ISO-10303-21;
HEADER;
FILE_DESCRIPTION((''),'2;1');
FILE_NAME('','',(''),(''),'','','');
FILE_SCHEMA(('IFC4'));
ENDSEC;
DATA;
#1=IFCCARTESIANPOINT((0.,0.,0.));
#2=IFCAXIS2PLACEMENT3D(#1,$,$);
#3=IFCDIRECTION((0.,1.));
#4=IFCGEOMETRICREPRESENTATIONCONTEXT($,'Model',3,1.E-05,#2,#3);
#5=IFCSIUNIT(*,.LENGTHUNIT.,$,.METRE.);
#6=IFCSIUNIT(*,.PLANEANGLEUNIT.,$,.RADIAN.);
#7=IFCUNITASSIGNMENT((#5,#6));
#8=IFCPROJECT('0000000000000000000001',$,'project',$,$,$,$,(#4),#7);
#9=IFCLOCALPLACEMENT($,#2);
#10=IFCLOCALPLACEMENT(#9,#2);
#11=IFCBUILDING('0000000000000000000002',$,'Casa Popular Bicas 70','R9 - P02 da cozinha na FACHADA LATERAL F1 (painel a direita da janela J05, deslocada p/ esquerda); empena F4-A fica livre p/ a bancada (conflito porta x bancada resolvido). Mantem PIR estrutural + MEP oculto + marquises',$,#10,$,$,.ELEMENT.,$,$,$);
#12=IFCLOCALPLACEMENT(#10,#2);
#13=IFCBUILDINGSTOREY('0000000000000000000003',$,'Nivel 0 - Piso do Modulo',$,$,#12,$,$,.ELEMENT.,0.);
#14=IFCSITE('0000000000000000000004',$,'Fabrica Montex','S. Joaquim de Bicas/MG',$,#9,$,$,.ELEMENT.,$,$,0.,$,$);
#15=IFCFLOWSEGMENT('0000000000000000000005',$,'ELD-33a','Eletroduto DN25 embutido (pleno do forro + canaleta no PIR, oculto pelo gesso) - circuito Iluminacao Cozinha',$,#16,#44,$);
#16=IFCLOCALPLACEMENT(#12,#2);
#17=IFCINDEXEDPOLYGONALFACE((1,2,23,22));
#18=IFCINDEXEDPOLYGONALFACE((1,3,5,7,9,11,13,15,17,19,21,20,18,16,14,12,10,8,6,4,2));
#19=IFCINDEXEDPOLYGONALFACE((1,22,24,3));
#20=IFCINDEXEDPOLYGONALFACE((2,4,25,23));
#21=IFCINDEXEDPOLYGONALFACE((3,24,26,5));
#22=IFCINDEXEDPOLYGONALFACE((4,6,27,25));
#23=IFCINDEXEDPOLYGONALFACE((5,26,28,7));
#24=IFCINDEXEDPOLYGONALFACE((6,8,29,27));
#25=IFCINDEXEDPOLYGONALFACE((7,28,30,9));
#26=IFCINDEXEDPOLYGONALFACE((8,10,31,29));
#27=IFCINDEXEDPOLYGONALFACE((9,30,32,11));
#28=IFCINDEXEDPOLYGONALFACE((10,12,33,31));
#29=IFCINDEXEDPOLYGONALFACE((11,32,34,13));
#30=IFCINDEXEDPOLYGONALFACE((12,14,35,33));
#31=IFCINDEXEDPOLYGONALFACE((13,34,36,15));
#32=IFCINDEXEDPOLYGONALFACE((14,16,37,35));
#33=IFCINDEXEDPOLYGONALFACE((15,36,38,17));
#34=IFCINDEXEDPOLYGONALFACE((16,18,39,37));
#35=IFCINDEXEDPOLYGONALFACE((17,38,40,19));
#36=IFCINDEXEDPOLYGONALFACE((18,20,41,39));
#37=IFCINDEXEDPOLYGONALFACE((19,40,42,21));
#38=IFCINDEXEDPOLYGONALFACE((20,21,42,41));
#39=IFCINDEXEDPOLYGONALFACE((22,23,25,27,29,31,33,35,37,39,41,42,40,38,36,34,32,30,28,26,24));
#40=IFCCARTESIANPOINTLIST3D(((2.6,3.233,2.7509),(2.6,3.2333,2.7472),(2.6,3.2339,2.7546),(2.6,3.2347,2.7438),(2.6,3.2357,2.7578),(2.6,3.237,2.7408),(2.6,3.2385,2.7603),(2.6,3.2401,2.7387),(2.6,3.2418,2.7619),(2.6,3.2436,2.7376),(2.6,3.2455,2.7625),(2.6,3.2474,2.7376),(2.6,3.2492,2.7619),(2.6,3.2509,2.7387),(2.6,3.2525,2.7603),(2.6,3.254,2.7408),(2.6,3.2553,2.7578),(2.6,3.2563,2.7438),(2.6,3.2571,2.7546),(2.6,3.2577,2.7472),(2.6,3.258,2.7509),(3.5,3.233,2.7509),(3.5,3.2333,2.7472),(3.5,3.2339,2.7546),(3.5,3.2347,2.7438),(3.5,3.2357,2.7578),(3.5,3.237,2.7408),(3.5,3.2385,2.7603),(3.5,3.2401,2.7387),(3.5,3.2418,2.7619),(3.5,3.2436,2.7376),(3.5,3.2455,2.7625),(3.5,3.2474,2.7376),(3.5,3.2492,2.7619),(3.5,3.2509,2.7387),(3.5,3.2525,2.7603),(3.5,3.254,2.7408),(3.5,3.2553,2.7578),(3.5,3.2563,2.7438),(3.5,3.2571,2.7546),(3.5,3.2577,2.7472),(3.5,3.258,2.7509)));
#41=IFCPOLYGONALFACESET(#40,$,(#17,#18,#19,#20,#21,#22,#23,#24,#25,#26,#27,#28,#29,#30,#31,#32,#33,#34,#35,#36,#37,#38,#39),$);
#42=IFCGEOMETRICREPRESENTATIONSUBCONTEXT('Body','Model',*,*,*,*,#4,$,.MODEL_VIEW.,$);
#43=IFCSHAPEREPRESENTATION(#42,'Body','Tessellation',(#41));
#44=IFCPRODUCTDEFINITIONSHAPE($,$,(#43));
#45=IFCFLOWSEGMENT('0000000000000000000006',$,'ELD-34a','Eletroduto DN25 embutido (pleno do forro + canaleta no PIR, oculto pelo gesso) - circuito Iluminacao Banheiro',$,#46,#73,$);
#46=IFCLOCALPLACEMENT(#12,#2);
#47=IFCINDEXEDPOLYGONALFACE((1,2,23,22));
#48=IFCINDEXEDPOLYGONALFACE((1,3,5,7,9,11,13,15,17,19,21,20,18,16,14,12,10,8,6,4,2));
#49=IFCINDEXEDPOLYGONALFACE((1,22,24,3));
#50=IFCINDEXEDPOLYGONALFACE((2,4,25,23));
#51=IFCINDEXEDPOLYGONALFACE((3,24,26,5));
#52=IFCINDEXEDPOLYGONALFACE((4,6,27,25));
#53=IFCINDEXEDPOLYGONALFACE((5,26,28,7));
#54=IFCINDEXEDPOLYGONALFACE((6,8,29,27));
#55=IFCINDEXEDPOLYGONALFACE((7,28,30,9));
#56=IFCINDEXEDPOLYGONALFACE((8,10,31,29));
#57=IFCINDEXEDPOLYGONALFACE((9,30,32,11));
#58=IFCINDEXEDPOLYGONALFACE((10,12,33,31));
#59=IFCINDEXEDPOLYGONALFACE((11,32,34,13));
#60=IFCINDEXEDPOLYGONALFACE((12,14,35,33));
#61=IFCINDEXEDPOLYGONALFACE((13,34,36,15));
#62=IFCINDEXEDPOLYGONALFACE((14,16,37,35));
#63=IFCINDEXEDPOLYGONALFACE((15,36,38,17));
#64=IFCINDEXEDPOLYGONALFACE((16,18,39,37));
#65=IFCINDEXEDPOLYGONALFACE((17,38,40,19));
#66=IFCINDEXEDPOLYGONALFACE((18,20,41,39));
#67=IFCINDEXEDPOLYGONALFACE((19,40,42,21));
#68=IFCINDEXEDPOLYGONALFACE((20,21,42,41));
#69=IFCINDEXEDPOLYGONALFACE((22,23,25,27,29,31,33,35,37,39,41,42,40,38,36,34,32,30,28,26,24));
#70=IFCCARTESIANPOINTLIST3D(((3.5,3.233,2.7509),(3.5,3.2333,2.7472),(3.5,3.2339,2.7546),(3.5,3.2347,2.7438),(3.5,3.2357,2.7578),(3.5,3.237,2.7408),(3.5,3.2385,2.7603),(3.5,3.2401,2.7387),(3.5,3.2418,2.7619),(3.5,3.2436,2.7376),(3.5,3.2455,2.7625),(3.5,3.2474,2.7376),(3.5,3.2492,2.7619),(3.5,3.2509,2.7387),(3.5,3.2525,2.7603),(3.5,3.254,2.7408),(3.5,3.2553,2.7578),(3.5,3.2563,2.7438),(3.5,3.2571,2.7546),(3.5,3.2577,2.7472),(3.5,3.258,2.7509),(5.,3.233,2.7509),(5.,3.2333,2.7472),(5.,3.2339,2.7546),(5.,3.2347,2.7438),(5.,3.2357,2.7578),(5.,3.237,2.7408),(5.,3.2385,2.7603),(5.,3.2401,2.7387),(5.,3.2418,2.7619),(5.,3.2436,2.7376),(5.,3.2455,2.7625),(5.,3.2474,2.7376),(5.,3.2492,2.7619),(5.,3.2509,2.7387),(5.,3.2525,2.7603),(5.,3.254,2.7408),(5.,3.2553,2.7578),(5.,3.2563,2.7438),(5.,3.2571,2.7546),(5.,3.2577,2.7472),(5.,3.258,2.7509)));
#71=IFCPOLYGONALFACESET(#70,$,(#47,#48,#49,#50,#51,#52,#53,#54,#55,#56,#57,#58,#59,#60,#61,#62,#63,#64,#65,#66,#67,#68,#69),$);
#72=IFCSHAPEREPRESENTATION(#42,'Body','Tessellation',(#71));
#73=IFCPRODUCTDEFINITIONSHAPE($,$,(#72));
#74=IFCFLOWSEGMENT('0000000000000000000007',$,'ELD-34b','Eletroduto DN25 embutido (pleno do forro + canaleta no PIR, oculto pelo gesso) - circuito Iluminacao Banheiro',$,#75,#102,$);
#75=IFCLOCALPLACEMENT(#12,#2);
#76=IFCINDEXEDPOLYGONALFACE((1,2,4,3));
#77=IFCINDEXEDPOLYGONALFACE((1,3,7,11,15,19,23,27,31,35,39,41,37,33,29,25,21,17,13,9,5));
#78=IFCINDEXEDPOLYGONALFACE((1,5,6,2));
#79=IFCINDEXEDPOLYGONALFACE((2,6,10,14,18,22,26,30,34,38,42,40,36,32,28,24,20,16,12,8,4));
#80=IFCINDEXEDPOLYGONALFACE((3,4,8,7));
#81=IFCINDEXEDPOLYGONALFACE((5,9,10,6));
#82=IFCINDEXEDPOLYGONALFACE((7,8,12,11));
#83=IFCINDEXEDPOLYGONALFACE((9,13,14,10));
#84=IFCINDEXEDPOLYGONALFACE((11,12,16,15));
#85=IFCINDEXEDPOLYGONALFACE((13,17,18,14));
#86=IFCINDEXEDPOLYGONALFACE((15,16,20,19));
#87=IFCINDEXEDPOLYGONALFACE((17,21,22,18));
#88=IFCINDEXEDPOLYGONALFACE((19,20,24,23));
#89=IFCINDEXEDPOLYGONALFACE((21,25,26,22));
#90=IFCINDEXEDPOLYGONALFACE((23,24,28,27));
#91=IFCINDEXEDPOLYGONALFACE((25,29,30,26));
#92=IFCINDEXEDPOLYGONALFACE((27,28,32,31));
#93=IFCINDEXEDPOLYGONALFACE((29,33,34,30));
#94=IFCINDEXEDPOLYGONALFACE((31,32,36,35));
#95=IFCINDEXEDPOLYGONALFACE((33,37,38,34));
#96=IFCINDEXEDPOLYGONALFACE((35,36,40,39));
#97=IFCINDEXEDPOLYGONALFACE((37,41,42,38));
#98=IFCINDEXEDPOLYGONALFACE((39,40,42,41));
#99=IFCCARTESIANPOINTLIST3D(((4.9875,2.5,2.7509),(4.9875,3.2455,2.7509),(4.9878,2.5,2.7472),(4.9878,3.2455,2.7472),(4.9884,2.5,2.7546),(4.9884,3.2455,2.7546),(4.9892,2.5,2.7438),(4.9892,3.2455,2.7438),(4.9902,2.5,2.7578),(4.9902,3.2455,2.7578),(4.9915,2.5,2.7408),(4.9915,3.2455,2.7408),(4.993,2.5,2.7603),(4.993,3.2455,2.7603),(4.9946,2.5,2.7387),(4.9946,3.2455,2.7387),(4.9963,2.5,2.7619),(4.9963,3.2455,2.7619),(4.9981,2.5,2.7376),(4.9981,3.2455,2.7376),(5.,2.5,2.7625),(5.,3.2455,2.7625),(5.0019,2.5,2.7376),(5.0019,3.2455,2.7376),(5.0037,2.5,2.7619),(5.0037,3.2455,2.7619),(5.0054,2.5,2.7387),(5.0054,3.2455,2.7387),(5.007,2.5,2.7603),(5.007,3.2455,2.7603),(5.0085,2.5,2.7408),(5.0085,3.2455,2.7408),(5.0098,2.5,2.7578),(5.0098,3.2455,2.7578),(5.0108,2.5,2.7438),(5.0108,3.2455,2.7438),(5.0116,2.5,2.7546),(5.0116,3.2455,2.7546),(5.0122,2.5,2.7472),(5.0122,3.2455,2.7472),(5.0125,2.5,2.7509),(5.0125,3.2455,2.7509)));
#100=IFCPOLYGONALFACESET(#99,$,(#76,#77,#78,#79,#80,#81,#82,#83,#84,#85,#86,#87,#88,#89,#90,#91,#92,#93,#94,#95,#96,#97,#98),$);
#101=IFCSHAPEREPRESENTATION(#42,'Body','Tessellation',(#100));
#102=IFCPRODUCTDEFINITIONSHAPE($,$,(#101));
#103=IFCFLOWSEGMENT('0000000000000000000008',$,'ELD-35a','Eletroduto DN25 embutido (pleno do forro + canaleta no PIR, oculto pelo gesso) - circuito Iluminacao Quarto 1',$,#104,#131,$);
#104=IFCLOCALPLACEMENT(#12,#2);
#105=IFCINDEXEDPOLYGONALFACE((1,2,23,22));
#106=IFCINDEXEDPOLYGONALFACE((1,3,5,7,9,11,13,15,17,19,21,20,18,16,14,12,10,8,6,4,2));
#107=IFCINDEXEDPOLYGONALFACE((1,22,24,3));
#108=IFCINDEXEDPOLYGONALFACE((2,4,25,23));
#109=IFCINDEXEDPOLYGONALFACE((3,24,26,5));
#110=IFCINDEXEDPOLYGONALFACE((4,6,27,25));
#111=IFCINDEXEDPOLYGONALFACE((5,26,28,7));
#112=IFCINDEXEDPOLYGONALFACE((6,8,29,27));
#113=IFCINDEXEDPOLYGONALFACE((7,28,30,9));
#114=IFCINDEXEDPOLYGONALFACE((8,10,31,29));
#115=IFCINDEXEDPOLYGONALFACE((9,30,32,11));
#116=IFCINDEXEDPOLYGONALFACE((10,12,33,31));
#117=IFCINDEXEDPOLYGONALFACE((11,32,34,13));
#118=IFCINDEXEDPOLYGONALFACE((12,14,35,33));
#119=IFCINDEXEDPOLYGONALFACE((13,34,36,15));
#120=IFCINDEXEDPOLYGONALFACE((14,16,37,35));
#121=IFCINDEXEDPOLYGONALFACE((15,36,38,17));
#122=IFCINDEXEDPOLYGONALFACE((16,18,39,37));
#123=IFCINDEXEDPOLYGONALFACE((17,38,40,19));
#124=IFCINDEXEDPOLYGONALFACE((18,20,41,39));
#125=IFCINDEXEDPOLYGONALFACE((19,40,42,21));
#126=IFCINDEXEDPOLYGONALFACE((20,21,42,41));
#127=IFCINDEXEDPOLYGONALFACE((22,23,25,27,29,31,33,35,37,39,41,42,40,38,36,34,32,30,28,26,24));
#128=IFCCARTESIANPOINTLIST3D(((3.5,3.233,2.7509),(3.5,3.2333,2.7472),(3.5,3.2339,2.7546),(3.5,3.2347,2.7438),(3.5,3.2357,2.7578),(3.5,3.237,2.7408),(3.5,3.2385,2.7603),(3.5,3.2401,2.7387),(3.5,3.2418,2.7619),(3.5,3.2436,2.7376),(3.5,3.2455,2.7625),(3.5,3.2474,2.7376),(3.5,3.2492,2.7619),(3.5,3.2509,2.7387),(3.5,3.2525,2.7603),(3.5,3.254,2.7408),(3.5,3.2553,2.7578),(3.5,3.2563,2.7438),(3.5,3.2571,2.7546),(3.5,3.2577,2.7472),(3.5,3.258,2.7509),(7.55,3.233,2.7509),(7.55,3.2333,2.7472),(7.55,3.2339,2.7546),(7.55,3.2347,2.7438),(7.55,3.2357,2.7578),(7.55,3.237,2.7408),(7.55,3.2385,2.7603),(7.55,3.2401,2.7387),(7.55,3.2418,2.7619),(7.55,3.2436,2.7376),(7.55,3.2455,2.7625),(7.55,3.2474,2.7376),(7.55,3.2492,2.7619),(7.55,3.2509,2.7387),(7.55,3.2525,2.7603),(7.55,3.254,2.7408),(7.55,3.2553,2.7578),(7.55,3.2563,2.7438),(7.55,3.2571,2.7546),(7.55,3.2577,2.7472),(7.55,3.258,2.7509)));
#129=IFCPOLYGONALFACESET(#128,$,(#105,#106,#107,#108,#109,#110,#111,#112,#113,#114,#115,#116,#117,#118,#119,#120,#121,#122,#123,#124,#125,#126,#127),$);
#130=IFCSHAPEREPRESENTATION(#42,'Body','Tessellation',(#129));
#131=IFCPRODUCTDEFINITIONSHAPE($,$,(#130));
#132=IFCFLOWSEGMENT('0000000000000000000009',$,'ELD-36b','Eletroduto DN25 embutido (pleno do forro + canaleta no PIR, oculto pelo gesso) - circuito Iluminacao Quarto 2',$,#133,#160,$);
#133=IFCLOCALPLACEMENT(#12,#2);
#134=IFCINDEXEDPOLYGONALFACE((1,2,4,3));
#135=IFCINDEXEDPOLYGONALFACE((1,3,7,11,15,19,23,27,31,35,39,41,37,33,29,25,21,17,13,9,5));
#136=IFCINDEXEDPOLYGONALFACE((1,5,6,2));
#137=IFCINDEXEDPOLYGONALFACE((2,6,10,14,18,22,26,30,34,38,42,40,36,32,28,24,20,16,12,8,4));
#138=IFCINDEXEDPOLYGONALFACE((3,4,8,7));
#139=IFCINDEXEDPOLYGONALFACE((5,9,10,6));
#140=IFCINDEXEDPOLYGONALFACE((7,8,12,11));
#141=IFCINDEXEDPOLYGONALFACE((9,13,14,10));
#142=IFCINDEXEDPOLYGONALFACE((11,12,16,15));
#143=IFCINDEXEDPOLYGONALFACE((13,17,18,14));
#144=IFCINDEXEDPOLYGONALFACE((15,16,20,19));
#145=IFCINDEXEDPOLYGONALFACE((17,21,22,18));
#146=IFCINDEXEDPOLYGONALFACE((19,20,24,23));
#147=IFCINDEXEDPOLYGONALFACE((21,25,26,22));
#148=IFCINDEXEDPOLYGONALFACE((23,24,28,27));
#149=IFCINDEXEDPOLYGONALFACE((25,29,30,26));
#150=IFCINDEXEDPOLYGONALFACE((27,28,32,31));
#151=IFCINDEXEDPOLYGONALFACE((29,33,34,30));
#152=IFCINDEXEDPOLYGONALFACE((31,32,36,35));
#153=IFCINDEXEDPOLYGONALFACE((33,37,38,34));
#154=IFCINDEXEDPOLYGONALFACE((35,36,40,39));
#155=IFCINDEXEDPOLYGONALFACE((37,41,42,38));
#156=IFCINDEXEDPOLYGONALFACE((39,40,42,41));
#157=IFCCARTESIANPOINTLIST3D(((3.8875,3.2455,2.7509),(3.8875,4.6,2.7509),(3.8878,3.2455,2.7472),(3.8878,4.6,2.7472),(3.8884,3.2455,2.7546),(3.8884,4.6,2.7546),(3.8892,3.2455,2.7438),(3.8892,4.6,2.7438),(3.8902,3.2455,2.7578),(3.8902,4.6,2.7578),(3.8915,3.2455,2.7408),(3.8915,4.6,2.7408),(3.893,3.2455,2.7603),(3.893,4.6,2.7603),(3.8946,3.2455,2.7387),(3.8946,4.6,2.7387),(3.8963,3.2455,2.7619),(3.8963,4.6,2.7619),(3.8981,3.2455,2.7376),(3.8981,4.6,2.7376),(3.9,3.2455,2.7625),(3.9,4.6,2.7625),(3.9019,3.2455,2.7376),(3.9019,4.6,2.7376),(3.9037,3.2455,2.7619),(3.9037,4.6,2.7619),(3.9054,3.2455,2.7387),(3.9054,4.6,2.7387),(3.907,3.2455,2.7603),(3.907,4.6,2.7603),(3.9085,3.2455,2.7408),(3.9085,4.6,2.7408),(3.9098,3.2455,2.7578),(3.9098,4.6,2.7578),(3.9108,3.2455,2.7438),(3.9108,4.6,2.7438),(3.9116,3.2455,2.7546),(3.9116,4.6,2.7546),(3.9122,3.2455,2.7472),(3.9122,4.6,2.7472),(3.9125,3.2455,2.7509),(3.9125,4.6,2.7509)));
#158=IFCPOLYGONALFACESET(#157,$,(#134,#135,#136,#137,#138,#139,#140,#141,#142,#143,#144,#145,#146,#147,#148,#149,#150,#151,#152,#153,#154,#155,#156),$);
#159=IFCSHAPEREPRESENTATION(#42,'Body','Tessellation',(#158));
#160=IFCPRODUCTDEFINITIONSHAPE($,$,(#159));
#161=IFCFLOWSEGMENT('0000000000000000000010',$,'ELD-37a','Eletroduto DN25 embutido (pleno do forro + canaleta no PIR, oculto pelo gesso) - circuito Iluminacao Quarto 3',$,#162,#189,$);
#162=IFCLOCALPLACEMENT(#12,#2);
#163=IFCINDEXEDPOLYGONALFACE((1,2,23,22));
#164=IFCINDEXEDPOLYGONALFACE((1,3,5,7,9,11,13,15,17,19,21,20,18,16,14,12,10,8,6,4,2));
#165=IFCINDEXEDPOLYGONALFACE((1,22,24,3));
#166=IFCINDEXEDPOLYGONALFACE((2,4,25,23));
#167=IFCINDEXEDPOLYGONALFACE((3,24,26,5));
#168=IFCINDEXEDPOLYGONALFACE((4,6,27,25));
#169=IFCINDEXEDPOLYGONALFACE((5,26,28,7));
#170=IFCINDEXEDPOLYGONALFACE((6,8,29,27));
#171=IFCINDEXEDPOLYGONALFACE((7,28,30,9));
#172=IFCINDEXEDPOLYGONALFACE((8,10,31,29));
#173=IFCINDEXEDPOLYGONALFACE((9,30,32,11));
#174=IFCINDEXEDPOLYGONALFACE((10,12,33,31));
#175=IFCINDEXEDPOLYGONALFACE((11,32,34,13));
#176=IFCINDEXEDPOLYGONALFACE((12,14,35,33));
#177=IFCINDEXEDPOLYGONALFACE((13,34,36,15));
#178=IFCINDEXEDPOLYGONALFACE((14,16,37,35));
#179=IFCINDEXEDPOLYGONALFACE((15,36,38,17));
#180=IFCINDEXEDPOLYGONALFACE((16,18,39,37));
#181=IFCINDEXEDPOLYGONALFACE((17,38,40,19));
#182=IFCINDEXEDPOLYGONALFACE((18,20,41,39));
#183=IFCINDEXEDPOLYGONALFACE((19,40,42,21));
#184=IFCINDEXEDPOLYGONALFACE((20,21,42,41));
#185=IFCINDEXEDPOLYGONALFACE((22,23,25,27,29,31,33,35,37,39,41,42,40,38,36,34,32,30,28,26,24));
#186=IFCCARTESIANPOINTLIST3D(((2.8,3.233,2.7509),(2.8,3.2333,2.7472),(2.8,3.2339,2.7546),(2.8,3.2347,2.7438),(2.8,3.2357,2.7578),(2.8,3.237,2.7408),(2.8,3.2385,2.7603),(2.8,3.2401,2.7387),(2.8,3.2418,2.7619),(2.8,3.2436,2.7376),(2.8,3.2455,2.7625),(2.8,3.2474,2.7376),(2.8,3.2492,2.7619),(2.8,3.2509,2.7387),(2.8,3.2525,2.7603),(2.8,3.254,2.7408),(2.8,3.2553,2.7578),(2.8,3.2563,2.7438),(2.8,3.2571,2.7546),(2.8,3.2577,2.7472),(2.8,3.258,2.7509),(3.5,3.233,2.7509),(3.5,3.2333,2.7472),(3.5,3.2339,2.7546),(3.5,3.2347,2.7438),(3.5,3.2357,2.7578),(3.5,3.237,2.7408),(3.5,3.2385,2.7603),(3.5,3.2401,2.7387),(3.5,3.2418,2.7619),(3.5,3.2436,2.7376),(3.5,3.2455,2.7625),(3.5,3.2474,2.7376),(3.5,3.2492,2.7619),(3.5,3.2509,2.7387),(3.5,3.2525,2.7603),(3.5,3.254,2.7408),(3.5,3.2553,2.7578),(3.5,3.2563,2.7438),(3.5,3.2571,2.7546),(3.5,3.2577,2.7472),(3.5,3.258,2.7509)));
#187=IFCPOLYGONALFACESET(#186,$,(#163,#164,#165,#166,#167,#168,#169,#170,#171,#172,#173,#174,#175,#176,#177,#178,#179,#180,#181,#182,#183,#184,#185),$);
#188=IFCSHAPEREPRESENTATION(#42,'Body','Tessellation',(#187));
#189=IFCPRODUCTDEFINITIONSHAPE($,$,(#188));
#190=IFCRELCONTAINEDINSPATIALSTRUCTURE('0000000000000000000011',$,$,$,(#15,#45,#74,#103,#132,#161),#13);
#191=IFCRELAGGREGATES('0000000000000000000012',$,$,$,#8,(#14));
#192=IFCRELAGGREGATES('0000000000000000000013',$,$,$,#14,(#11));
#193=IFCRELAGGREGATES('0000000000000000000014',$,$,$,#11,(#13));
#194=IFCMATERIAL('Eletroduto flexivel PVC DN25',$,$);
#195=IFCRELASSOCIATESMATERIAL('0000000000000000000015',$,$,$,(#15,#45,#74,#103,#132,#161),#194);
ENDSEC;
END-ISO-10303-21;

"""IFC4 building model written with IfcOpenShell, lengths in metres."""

from ifc_helpers import new_model, si_unit, direction, frame, origin, origin_2d, place, context, subcontext, project, spatial, circle, extrude, material, element, save


model = new_model("IFC4")

# Units and contexts
model_context = context("Model", 3, precision=1e-05, world=origin(), true_north=direction((0.0, 1.0)))
body_context = subcontext(model_context, "Body", "Model", "MODEL_VIEW")
ifc_project = project(units=[si_unit("LENGTHUNIT", "METRE"), si_unit("PLANEANGLEUNIT", "RADIAN")], contexts=[model_context])

# Site, building, storey
site_placement = place(None, origin())
site = spatial("IfcSite", under=ifc_project, at=site_placement, Name="Fabrica Montex", Description="S. Joaquim de Bicas/MG", CompositionType="ELEMENT", RefElevation=0.0)
building_placement = place(site_placement, origin())
building = spatial("IfcBuilding", under=site, at=building_placement, Name="Casa Popular Bicas 70", Description="R9 - P02 da cozinha na FACHADA LATERAL F1 (painel a direita da janela J05, deslocada p/ esquerda); empena F4-A fica livre p/ a bancada (conflito porta x bancada resolvido). Mantem PIR estrutural + MEP oculto + marquises", CompositionType="ELEMENT")
storey_placement = place(building_placement, origin())
storey = spatial("IfcBuildingStorey", under=building, at=storey_placement, Name="Nivel 0 - Piso do Modulo", CompositionType="ELEMENT", Elevation=0.0)

# Flow segments
ifc_material_1 = material(Name="Eletroduto flexivel PVC DN25")
flow_segment_1_placement = place(storey_placement, frame((3.5, 3.2455, 2.75), z_axis=(-1.0, 0.0, 0.0), x_axis=(0.0, 0.0, 1.0)))
element("IfcFlowSegment", 1, at=flow_segment_1_placement, inside=storey, material=ifc_material_1, Name="ELD-33a", Description="Eletroduto DN25 embutido (pleno do forro + canaleta no PIR, oculto pelo gesso) - circuito Iluminacao Cozinha", context=body_context, shape_type="SweptSolid", body=[
    extrude(circle(Radius=0.0125, at=origin_2d()), origin(), (0.0, 0.0, 1.0), 0.9),
])
flow_segment_2_placement = place(storey_placement, frame((3.5, 3.2455, 2.75), z_axis=(1.0, 0.0, 0.0), x_axis=(0.0, 0.0, 1.0)))
element("IfcFlowSegment", 2, at=flow_segment_2_placement, inside=storey, material=ifc_material_1, Name="ELD-34a", Description="Eletroduto DN25 embutido (pleno do forro + canaleta no PIR, oculto pelo gesso) - circuito Iluminacao Banheiro", context=body_context, shape_type="SweptSolid", body=[
    extrude(circle(Radius=0.0125, at=origin_2d()), origin(), (0.0, 0.0, 1.0), 1.5),
])
flow_segment_3_placement = place(storey_placement, frame((5.0, 3.2455, 2.75), z_axis=(0.0, -1.0, 0.0), x_axis=(0.0, 0.0, 1.0)))
element("IfcFlowSegment", 3, at=flow_segment_3_placement, inside=storey, material=ifc_material_1, Name="ELD-34b", Description="Eletroduto DN25 embutido (pleno do forro + canaleta no PIR, oculto pelo gesso) - circuito Iluminacao Banheiro", context=body_context, shape_type="SweptSolid", body=[
    extrude(circle(Radius=0.0125, at=origin_2d()), origin(), (0.0, 0.0, 1.0), 0.7455),
])
flow_segment_4_placement = place(storey_placement, frame((3.5, 3.2455, 2.75), z_axis=(1.0, 0.0, 0.0), x_axis=(0.0, 0.0, 1.0)))
element("IfcFlowSegment", 4, at=flow_segment_4_placement, inside=storey, material=ifc_material_1, Name="ELD-35a", Description="Eletroduto DN25 embutido (pleno do forro + canaleta no PIR, oculto pelo gesso) - circuito Iluminacao Quarto 1", context=body_context, shape_type="SweptSolid", body=[
    extrude(circle(Radius=0.0125, at=origin_2d()), origin(), (0.0, 0.0, 1.0), 4.05),
])
flow_segment_5_placement = place(storey_placement, frame((3.9, 3.2455, 2.75), z_axis=(0.0, 1.0, 0.0), x_axis=(0.0, 0.0, 1.0)))
element("IfcFlowSegment", 5, at=flow_segment_5_placement, inside=storey, material=ifc_material_1, Name="ELD-36b", Description="Eletroduto DN25 embutido (pleno do forro + canaleta no PIR, oculto pelo gesso) - circuito Iluminacao Quarto 2", context=body_context, shape_type="SweptSolid", body=[
    extrude(circle(Radius=0.0125, at=origin_2d()), origin(), (0.0, 0.0, 1.0), 1.3545),
])
flow_segment_6_placement = place(storey_placement, frame((3.5, 3.2455, 2.75), z_axis=(-1.0, 0.0, 0.0), x_axis=(0.0, 0.0, 1.0)))
element("IfcFlowSegment", 6, at=flow_segment_6_placement, inside=storey, material=ifc_material_1, Name="ELD-37a", Description="Eletroduto DN25 embutido (pleno do forro + canaleta no PIR, oculto pelo gesso) - circuito Iluminacao Quarto 3", context=body_context, shape_type="SweptSolid", body=[
    extrude(circle(Radius=0.0125, at=origin_2d()), origin(), (0.0, 0.0, 1.0), 0.7),
])

save(model, "model.ifc")
